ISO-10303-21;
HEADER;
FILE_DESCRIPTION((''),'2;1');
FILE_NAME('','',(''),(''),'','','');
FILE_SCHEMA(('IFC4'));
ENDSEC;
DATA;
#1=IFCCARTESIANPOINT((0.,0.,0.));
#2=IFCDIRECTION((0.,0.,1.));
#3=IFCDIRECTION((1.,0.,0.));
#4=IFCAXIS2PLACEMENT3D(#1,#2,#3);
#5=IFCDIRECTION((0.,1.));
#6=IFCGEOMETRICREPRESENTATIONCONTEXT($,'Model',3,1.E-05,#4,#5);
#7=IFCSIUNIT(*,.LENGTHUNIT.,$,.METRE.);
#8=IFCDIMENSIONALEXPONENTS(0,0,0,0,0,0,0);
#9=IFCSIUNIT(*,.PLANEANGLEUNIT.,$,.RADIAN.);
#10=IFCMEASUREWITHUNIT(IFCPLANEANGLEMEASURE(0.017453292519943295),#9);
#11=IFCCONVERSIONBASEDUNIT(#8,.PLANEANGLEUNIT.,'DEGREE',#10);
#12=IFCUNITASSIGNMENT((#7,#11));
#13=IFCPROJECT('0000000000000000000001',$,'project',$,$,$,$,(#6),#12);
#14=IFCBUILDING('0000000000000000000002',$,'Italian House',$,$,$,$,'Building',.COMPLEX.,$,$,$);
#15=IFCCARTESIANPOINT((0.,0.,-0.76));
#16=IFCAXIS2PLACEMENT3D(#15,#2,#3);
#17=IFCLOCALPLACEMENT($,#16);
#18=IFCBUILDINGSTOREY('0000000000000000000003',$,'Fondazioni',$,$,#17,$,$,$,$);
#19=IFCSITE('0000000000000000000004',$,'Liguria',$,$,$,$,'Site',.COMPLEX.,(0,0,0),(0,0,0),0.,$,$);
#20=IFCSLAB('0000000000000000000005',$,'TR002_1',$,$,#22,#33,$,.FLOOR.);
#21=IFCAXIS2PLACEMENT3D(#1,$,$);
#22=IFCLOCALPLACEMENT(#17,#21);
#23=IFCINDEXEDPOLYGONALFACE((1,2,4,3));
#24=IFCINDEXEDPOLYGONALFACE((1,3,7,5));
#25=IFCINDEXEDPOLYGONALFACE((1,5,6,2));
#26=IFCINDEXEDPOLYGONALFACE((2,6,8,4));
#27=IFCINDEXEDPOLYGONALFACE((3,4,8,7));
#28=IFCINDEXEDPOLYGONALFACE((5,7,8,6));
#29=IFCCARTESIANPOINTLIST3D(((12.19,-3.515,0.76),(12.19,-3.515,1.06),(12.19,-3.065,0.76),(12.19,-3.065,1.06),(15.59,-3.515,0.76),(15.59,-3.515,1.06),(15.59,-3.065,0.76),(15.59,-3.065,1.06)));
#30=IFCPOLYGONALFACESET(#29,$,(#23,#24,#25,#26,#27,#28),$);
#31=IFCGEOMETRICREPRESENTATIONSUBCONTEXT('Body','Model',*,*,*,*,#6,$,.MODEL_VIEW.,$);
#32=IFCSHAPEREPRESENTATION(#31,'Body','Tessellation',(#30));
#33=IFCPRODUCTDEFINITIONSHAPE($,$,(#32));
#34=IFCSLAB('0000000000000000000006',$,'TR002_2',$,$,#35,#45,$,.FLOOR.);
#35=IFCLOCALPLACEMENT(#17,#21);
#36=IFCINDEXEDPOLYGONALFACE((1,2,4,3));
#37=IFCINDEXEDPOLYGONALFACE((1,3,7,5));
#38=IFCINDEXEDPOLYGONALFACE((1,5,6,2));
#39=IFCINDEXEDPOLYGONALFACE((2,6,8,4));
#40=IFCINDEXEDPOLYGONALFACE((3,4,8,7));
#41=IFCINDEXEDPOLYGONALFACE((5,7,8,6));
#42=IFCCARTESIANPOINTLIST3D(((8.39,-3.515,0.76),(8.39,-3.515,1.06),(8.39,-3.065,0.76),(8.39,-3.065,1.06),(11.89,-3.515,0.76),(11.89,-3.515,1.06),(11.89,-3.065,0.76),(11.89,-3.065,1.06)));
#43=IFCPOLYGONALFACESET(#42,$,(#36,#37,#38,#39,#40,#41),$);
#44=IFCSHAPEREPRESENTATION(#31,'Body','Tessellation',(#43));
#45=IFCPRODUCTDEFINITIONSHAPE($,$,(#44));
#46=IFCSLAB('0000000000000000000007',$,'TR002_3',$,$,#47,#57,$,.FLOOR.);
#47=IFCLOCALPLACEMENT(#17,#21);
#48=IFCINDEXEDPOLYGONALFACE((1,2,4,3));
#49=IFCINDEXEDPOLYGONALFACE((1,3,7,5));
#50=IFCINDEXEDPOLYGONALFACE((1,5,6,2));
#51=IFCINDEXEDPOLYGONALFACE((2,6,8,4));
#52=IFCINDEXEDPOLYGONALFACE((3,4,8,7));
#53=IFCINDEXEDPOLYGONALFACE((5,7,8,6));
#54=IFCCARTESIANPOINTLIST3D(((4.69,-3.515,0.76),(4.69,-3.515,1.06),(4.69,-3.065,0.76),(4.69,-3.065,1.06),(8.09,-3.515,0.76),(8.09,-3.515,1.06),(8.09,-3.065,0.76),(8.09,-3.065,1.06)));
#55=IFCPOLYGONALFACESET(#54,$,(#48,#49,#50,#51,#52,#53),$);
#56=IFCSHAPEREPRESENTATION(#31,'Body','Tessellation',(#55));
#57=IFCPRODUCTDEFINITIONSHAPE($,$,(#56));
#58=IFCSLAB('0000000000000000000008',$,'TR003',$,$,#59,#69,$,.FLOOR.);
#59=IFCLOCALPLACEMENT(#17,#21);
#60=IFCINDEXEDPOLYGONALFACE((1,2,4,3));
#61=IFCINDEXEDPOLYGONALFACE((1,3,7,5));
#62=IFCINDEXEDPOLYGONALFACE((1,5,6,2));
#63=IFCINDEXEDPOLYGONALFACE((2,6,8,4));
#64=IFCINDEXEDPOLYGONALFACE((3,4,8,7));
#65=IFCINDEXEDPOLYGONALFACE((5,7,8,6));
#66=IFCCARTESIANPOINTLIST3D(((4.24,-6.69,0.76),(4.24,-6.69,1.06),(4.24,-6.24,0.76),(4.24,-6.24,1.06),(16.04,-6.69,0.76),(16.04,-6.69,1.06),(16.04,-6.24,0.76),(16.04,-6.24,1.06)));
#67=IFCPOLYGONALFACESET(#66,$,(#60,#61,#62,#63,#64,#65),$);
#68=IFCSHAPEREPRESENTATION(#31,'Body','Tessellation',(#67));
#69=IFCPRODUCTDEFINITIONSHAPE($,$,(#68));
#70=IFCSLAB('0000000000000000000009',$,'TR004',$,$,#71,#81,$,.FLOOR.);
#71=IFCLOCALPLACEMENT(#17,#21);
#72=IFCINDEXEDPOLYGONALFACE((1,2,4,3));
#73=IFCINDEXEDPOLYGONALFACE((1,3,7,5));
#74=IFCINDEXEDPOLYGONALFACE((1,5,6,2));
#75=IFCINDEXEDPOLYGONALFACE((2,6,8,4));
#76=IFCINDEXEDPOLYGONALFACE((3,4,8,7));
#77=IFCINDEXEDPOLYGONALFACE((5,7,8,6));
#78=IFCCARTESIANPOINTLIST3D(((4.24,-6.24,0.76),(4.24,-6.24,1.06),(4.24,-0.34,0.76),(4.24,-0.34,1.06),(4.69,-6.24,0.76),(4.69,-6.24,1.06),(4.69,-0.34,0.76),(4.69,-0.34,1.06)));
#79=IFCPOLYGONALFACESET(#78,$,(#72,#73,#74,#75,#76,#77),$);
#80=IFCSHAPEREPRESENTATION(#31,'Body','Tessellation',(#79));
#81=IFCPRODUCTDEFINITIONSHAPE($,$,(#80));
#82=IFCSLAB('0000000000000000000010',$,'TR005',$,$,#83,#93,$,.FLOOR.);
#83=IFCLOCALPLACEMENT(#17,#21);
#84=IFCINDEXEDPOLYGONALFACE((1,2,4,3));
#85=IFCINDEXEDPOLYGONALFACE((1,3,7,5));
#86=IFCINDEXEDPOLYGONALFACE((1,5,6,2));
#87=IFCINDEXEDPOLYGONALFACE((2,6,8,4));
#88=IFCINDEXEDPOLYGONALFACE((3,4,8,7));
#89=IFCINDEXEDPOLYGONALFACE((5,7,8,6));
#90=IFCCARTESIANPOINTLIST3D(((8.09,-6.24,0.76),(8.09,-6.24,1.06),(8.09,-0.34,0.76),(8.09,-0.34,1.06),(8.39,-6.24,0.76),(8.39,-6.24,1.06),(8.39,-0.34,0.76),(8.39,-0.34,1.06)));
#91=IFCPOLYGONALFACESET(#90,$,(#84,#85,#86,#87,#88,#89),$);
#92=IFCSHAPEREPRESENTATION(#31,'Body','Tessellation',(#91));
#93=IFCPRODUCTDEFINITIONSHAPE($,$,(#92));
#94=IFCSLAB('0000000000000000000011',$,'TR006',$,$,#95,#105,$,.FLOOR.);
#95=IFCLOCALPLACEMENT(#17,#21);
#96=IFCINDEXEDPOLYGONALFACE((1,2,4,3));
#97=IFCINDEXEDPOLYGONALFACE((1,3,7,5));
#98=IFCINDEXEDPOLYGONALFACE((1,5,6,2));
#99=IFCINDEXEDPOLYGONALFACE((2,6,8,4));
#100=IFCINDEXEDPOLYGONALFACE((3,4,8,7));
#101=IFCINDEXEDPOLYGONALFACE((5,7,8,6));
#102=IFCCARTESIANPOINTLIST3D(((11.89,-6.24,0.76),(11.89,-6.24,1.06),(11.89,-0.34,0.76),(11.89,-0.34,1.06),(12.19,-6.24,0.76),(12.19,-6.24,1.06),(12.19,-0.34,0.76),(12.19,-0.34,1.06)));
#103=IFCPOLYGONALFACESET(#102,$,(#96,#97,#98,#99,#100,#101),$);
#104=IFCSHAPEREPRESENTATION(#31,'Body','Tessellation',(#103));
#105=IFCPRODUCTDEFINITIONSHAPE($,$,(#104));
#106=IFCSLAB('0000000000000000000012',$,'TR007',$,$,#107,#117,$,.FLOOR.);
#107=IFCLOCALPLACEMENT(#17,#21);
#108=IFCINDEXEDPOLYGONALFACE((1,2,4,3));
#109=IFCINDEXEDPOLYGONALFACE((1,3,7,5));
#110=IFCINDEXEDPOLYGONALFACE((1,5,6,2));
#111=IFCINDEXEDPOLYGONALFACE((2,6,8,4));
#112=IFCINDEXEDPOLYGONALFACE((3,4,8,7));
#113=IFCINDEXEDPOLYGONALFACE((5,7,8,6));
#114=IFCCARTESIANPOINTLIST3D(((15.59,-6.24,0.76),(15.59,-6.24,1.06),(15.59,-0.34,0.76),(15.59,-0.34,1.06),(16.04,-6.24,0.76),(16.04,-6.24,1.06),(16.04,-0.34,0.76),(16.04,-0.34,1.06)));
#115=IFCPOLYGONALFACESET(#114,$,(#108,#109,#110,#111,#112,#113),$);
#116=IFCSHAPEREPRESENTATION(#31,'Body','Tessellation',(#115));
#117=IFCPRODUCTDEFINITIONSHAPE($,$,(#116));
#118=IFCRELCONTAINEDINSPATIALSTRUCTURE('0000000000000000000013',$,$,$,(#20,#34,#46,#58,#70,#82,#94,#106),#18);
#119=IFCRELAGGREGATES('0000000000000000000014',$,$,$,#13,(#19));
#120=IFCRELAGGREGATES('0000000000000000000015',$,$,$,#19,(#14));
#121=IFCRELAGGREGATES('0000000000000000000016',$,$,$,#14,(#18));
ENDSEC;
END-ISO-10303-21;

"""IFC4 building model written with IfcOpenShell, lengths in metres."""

from ifc_helpers import new_model, entity, si_unit, converted_unit, direction, frame, frame_2d, origin_with_axes, origin_2d_with_axis, place, context, subcontext, project, spatial, rectangle, extrude, element, save


model = new_model("IFC4")

# Units and contexts
model_context = context("Model", 3, precision=1e-05, world=origin_with_axes(), true_north=direction((0.0, 1.0)))
body_context = subcontext(model_context, "Body", "Model", "MODEL_VIEW")
ifc_project = project(units=[si_unit("LENGTHUNIT", "METRE"), converted_unit("PLANEANGLEUNIT", "DEGREE", entity("IfcPlaneAngleMeasure", 0.017453292519943295), si_unit("PLANEANGLEUNIT", "RADIAN"), dimensions=[0, 0, 0, 0, 0, 0, 0])], contexts=[model_context])

# Site, building, storey
site = spatial("IfcSite", under=ifc_project, Name="Liguria", LongName="Site", CompositionType="COMPLEX", RefLatitude=(0, 0, 0), RefLongitude=(0, 0, 0), RefElevation=0.0)
building = spatial("IfcBuilding", under=site, Name="Italian House", LongName="Building", CompositionType="COMPLEX")
storey_placement = place(None, frame((0.0, 0.0, -0.76), z_axis=(0.0, 0.0, 1.0), x_axis=(1.0, 0.0, 0.0)))
storey = spatial("IfcBuildingStorey", under=building, at=storey_placement, Name="Fondazioni")

# Slabs
slab_1_placement = place(storey_placement, frame((0.0, 0.0, 0.76), z_axis=(0.0, 0.0, 1.0), x_axis=(1.0, 0.0, 0.0)))
element("IfcSlab", 1, at=slab_1_placement, inside=storey, Name="TR002_1", PredefinedType="FLOOR", context=body_context, shape_type="SweptSolid", body=[
    extrude(rectangle(XDim=3.4, YDim=0.45, at=origin_2d_with_axis()), frame((13.89, -3.29, 0.3), z_axis=(0.0, 0.0, 1.0), x_axis=(1.0, 0.0, 0.0)), (0.0, 0.0, -1.0), 0.3),
])
slab_2_placement = place(storey_placement, frame((0.0, 0.0, 0.76), z_axis=(0.0, 0.0, 1.0), x_axis=(1.0, 0.0, 0.0)))
element("IfcSlab", 2, at=slab_2_placement, inside=storey, Name="TR002_2", PredefinedType="FLOOR", context=body_context, shape_type="SweptSolid", body=[
    extrude(rectangle(XDim=3.5, YDim=0.45, at=origin_2d_with_axis()), frame((10.14, -3.29, 0.3), z_axis=(0.0, 0.0, 1.0), x_axis=(1.0, 0.0, 0.0)), (0.0, 0.0, -1.0), 0.3),
])
slab_3_placement = place(storey_placement, frame((0.0, 0.0, 0.76), z_axis=(0.0, 0.0, 1.0), x_axis=(1.0, 0.0, 0.0)))
element("IfcSlab", 3, at=slab_3_placement, inside=storey, Name="TR002_3", PredefinedType="FLOOR", context=body_context, shape_type="SweptSolid", body=[
    extrude(rectangle(XDim=3.4, YDim=0.45, at=origin_2d_with_axis()), frame((6.39, -3.29, 0.3), z_axis=(0.0, 0.0, 1.0), x_axis=(1.0, 0.0, 0.0)), (0.0, 0.0, -1.0), 0.3),
])
slab_4_placement = place(storey_placement, frame((0.0, 0.0, 0.76), z_axis=(0.0, 0.0, 1.0), x_axis=(1.0, 0.0, 0.0)))
element("IfcSlab", 4, at=slab_4_placement, inside=storey, Name="TR003", PredefinedType="FLOOR", context=body_context, shape_type="SweptSolid", body=[
    extrude(rectangle(XDim=11.8, YDim=0.45, at=frame_2d((0.0, 0.0), x_axis=(1.0, 0.0))), frame((10.14, -6.465, 0.3), z_axis=(0.0, 0.0, 1.0), x_axis=(1.0, 0.0, 0.0)), (0.0, 0.0, -1.0), 0.3),
])
slab_5_placement = place(storey_placement, frame((0.0, 0.0, 0.76), z_axis=(0.0, 0.0, 1.0), x_axis=(1.0, 0.0, 0.0)))
element("IfcSlab", 5, at=slab_5_placement, inside=storey, Name="TR004", PredefinedType="FLOOR", context=body_context, shape_type="SweptSolid", body=[
    extrude(rectangle(XDim=0.45, YDim=5.9, at=origin_2d_with_axis()), frame((4.465, -3.29, 0.3), z_axis=(0.0, 0.0, 1.0), x_axis=(1.0, 0.0, 0.0)), (0.0, 0.0, -1.0), 0.3),
])
slab_6_placement = place(storey_placement, frame((0.0, 0.0, 0.76), z_axis=(0.0, 0.0, 1.0), x_axis=(1.0, 0.0, 0.0)))
element("IfcSlab", 6, at=slab_6_placement, inside=storey, Name="TR005", PredefinedType="FLOOR", context=body_context, shape_type="SweptSolid", body=[
    extrude(rectangle(XDim=0.3, YDim=5.9, at=origin_2d_with_axis()), frame((8.24, -3.29, 0.3), z_axis=(0.0, 0.0, 1.0), x_axis=(1.0, 0.0, 0.0)), (0.0, 0.0, -1.0), 0.3),
])
slab_7_placement = place(storey_placement, frame((0.0, 0.0, 0.76), z_axis=(0.0, 0.0, 1.0), x_axis=(1.0, 0.0, 0.0)))
element("IfcSlab", 7, at=slab_7_placement, inside=storey, Name="TR006", PredefinedType="FLOOR", context=body_context, shape_type="SweptSolid", body=[
    extrude(rectangle(XDim=0.3, YDim=5.9, at=origin_2d_with_axis()), frame((12.04, -3.29, 0.3), z_axis=(0.0, 0.0, 1.0), x_axis=(1.0, 0.0, 0.0)), (0.0, 0.0, -1.0), 0.3),
])
slab_8_placement = place(storey_placement, frame((0.0, 0.0, 0.76), z_axis=(0.0, 0.0, 1.0), x_axis=(1.0, 0.0, 0.0)))
element("IfcSlab", 8, at=slab_8_placement, inside=storey, Name="TR007", PredefinedType="FLOOR", context=body_context, shape_type="SweptSolid", body=[
    extrude(rectangle(XDim=0.45, YDim=5.9, at=origin_2d_with_axis()), frame((15.815, -3.29, 0.3), z_axis=(0.0, 0.0, 1.0), x_axis=(1.0, 0.0, 0.0)), (0.0, 0.0, -1.0), 0.3),
])

save(model, "model.ifc")
